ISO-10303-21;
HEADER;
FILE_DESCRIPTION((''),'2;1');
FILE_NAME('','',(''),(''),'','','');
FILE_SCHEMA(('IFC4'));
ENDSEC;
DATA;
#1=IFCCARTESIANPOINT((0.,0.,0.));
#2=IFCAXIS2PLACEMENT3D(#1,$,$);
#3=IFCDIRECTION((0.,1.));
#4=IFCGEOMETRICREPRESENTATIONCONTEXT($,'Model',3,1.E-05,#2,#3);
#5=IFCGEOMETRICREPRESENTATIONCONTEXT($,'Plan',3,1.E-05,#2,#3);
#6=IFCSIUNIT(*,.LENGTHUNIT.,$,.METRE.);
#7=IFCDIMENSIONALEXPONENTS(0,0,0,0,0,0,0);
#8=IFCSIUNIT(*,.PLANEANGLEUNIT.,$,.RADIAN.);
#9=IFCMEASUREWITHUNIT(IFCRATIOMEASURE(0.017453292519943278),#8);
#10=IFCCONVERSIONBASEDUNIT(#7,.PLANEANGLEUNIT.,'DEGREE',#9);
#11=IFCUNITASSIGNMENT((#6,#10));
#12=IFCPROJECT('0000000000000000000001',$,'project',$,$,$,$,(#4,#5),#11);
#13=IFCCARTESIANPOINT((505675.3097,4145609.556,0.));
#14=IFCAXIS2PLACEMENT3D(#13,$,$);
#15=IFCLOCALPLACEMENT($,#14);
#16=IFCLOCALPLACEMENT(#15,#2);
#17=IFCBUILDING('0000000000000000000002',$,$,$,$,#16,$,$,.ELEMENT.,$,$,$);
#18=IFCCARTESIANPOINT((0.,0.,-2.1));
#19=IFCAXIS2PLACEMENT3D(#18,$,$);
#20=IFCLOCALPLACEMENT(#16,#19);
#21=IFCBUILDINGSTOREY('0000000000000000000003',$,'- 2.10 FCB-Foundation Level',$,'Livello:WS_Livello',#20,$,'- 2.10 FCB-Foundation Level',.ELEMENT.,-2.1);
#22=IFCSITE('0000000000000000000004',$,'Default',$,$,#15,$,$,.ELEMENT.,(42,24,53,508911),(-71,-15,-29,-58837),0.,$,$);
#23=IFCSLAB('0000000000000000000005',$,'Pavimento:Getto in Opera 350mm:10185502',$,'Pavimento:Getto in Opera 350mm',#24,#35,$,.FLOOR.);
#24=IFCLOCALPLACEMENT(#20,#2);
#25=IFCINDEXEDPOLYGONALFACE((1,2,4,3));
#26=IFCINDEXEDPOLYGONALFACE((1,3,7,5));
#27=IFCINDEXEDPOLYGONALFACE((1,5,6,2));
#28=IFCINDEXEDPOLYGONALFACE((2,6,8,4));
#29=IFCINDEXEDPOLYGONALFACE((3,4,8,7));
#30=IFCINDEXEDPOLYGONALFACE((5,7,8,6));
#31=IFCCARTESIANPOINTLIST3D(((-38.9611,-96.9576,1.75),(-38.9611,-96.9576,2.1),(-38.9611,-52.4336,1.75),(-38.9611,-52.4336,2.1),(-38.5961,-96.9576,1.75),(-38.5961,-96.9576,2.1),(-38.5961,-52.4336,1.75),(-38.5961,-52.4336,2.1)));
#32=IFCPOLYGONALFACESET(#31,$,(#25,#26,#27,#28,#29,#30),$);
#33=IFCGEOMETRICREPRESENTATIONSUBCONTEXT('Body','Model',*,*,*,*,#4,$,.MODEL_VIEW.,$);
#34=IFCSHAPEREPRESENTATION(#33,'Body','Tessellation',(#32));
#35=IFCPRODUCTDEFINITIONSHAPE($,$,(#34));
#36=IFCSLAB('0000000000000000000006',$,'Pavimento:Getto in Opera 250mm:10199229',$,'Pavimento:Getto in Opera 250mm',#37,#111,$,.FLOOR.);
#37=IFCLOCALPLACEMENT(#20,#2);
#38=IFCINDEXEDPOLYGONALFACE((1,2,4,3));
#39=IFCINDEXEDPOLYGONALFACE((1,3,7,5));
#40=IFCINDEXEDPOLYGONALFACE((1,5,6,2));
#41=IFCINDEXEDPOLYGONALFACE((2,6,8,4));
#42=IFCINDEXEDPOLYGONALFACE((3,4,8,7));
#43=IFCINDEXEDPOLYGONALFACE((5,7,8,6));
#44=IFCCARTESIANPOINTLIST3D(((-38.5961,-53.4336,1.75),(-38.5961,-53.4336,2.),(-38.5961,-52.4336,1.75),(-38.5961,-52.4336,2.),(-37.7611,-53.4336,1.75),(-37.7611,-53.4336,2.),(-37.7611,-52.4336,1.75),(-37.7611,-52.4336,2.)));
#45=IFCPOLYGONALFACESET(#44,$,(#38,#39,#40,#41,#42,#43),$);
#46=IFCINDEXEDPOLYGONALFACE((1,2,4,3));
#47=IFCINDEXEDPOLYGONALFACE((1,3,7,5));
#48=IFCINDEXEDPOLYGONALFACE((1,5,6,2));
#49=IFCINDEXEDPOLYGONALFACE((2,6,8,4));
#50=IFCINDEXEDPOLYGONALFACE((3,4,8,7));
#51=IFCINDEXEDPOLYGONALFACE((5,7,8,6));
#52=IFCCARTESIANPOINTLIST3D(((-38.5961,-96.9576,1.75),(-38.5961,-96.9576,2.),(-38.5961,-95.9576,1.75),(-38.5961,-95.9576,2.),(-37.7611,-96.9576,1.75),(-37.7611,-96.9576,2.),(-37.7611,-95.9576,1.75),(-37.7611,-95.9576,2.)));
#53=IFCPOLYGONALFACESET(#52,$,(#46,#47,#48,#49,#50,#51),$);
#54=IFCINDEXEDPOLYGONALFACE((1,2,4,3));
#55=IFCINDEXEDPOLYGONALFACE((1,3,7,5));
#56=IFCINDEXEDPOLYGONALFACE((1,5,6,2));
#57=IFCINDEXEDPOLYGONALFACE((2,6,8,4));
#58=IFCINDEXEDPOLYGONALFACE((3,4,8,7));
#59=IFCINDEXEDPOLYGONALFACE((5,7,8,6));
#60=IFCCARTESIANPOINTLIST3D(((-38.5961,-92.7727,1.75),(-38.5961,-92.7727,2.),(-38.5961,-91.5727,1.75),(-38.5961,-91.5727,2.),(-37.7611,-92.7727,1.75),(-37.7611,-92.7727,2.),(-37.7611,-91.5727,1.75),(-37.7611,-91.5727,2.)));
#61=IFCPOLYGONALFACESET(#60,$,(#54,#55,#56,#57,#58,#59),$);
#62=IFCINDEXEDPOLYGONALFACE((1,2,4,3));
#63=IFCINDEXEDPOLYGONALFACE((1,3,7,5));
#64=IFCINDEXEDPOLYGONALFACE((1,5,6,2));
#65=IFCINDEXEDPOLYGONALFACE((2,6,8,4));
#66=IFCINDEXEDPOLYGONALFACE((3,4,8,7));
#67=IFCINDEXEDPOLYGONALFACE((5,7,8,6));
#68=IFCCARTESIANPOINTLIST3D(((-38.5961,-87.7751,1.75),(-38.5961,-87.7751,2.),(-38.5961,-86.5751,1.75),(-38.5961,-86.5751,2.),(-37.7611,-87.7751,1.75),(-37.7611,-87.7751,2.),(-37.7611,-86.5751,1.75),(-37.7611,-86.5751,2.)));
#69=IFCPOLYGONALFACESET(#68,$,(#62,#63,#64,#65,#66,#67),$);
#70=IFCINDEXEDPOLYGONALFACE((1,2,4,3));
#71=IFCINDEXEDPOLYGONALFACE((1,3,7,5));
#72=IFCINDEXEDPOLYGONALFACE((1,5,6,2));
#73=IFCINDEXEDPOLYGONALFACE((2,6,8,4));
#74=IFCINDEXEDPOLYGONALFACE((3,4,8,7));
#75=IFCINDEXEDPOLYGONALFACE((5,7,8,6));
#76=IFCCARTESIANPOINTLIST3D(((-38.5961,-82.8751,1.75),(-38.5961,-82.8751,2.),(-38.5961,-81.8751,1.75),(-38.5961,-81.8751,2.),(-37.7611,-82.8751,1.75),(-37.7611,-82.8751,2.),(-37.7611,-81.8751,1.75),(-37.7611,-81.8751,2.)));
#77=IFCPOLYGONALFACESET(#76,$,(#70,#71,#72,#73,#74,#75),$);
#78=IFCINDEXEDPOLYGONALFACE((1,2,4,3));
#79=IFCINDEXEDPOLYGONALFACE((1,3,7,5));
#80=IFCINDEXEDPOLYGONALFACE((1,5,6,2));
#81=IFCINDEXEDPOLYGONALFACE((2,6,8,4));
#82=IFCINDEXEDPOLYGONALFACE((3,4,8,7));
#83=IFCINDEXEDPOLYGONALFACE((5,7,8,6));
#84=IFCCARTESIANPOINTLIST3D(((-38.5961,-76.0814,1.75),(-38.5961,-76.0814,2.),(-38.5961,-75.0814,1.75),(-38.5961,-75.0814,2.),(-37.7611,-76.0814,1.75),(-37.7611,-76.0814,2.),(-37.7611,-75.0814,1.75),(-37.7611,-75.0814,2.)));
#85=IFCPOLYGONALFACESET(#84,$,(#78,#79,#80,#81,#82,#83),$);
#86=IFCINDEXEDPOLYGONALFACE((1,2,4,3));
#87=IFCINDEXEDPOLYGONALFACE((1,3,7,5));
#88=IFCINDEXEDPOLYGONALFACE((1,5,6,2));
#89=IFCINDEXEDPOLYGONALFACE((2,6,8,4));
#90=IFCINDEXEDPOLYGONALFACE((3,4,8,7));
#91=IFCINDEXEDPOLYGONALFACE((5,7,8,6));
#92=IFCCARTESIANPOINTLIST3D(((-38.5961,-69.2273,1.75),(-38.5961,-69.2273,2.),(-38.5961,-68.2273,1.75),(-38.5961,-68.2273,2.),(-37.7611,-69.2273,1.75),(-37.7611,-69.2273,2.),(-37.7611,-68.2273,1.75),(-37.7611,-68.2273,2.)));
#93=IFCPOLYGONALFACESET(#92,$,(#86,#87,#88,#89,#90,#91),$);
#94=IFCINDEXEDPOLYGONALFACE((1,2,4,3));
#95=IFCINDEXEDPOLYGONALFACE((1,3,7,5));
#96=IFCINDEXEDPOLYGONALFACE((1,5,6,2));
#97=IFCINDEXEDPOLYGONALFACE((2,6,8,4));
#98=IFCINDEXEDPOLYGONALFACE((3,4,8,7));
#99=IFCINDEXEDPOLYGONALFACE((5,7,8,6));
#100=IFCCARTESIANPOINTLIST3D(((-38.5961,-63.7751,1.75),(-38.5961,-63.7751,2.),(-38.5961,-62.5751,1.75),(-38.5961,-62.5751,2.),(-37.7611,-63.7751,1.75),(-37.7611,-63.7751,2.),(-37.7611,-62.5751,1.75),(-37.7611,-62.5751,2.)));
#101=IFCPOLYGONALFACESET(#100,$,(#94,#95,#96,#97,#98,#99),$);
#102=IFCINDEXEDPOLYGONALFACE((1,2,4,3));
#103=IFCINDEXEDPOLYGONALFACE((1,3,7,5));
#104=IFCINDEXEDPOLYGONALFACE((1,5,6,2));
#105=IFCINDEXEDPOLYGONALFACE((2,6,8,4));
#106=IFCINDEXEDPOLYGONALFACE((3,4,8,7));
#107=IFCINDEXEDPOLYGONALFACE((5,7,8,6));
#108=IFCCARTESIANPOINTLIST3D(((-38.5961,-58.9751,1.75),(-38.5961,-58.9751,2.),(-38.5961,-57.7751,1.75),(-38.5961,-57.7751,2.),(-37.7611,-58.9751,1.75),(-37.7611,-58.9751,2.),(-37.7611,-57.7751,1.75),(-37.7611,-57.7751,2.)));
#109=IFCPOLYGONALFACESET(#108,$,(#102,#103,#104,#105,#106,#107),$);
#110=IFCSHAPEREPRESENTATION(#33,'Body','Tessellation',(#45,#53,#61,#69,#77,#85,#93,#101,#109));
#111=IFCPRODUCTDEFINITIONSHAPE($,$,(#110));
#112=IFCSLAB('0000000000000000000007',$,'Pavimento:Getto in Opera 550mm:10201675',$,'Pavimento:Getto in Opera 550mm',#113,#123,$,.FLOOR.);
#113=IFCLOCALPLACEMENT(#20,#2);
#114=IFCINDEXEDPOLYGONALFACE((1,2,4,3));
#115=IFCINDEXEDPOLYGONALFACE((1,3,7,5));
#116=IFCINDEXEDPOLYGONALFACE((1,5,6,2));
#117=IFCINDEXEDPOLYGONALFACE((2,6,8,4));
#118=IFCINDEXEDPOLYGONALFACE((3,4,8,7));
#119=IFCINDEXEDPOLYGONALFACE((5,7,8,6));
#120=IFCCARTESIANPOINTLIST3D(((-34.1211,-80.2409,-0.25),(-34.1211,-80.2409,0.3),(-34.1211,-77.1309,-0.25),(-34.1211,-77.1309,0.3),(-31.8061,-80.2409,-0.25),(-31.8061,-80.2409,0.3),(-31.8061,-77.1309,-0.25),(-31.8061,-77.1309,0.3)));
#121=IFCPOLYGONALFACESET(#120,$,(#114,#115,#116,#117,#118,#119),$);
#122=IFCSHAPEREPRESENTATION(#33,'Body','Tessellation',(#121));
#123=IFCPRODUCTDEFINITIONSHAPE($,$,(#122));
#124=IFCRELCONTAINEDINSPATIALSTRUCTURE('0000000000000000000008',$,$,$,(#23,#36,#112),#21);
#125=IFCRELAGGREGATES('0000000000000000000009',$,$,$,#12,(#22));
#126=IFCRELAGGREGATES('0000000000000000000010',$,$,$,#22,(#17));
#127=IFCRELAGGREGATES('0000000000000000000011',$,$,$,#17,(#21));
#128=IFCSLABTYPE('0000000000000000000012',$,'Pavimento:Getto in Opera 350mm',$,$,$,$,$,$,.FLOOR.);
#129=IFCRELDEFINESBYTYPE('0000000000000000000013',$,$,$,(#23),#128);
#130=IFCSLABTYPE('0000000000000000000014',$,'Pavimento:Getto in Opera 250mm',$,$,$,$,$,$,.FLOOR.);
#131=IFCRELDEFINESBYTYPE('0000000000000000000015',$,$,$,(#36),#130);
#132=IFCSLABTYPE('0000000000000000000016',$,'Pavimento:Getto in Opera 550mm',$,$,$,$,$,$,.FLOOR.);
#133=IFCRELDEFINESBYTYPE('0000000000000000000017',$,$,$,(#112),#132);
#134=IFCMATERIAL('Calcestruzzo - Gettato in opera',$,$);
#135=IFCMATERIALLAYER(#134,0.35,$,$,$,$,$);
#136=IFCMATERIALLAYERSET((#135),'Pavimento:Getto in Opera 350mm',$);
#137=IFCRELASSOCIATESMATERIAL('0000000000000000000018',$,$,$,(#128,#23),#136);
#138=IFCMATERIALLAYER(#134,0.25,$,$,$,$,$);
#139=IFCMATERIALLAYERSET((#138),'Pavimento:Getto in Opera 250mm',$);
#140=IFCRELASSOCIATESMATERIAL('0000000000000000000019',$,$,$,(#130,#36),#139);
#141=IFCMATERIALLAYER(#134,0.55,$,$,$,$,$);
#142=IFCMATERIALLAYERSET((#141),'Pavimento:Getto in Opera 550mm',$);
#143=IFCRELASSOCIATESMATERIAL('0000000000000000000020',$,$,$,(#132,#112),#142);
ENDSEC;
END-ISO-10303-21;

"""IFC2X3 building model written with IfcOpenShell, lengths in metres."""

from ifc_helpers import new_model, entity, si_unit, converted_unit, direction, frame, frame_2d, origin, place, context, subcontext, project, spatial, rectangle, extrude, material, layer, layer_set, layer_usage, type_object, element, save


model = new_model("IFC2X3")

# Units and contexts
model_context = context("Model", 3, precision=1e-05, world=origin(), true_north=direction((0.0, 1.0)))
plan_context = context("Plan", 3, precision=1e-05, world=origin(), true_north=direction((0.0, 1.0)))
body_context = subcontext(model_context, "Body", "Model", "MODEL_VIEW")
ifc_project = project(units=[si_unit("LENGTHUNIT", "METRE"), converted_unit("PLANEANGLEUNIT", "DEGREE", entity("IfcRatioMeasure", 0.017453292519943278), si_unit("PLANEANGLEUNIT", "RADIAN"), dimensions=[0, 0, 0, 0, 0, 0, 0])], contexts=[model_context, plan_context])

# Site, building, storey
site_placement = place(None, frame((505675.3097, 4145609.556, 0.0)))
site = spatial("IfcSite", under=ifc_project, at=site_placement, Name="Default", CompositionType="ELEMENT", RefLatitude=(42, 24, 53, 508911), RefLongitude=(-71, -15, -29, -58837), RefElevation=0.0)
building_placement = place(site_placement, origin())
building = spatial("IfcBuilding", under=site, at=building_placement, CompositionType="ELEMENT")
storey_placement = place(building_placement, frame((0.0, 0.0, -2.1)))
storey = spatial("IfcBuildingStorey", under=building, at=storey_placement, Name="- 2.10 FCB-Foundation Level", ObjectType="Livello:WS_Livello", LongName="- 2.10 FCB-Foundation Level", CompositionType="ELEMENT", Elevation=-2.1)

# Slab
ifc_material_1 = material(Name="Calcestruzzo - Gettato in opera")
ifc_layer_1 = layer(ifc_material_1, 0.35)
ifc_layer_set_1 = layer_set([ifc_layer_1], Name="Pavimento:Getto in Opera 350mm")
ifc_layer_usage_1 = layer_usage(ifc_layer_set_1, "AXIS3", "POSITIVE", 0.0)
slab_type_1 = type_object("IfcSlabType", Name="Pavimento:Getto in Opera 350mm", PredefinedType="FLOOR", material=ifc_layer_set_1)
slab_1_placement = place(storey_placement, origin())
element("IfcSlab", 1, at=slab_1_placement, inside=storey, type_object=slab_type_1, material=ifc_layer_usage_1, Name="Pavimento:Getto in Opera 350mm:10185502", ObjectType="Pavimento:Getto in Opera 350mm", PredefinedType="FLOOR", context=body_context, shape_type="SweptSolid", body=[
    extrude(rectangle(XDim=44.524, YDim=0.365, at=frame_2d((0.0, 0.0), x_axis=(1.0, 0.0))), frame((-38.7786, -74.6956, 2.1), z_axis=(0.0, 0.0, -1.0), x_axis=(0.0, 1.0, 0.0)), (0.0, 0.0, 1.0), 0.35),
])

# Slabs
ifc_layer_2 = layer(ifc_material_1, 0.25)
ifc_layer_set_2 = layer_set([ifc_layer_2], Name="Pavimento:Getto in Opera 250mm")
ifc_layer_usage_2 = layer_usage(ifc_layer_set_2, "AXIS3", "POSITIVE", 0.0)
slab_type_2 = type_object("IfcSlabType", Name="Pavimento:Getto in Opera 250mm", PredefinedType="FLOOR", material=ifc_layer_set_2)
slab_2_placement = place(storey_placement, origin())
element("IfcSlab", 2, at=slab_2_placement, inside=storey, type_object=slab_type_2, material=ifc_layer_usage_2, Name="Pavimento:Getto in Opera 250mm:10199229", ObjectType="Pavimento:Getto in Opera 250mm", PredefinedType="FLOOR", context=body_context, shape_type="SweptSolid", body=[
    extrude(rectangle(XDim=0.835, YDim=1.0, at=frame_2d((0.0, 0.0), x_axis=(1.0, 0.0))), frame((-38.1786, -52.9336, 1.75), z_axis=(0.0, 0.0, 1.0), x_axis=(-1.0, 0.0, 0.0)), (0.0, 0.0, 1.0), 0.25),
    extrude(rectangle(XDim=0.8349, YDim=1.0, at=frame_2d((0.0, 0.0), x_axis=(1.0, 0.0))), frame((-38.1786, -96.4576, 1.75), z_axis=(0.0, 0.0, 1.0), x_axis=(-1.0, 0.0, 0.0)), (0.0, 0.0, 1.0), 0.25),
    extrude(rectangle(XDim=0.835, YDim=1.2, at=frame_2d((0.0, 0.0), x_axis=(1.0, 0.0))), frame((-38.1786, -92.1727, 1.75), z_axis=(0.0, 0.0, 1.0), x_axis=(-1.0, 0.0, 0.0)), (0.0, 0.0, 1.0), 0.25),
    extrude(rectangle(XDim=0.835, YDim=1.2, at=frame_2d((0.0, 0.0), x_axis=(1.0, 0.0))), frame((-38.1786, -87.1751, 1.75), z_axis=(0.0, 0.0, 1.0), x_axis=(-1.0, 0.0, 0.0)), (0.0, 0.0, 1.0), 0.25),
    extrude(rectangle(XDim=0.835, YDim=1.0, at=frame_2d((0.0, 0.0), x_axis=(1.0, 0.0))), frame((-38.1786, -82.3751, 1.75), z_axis=(0.0, 0.0, 1.0), x_axis=(-1.0, 0.0, 0.0)), (0.0, 0.0, 1.0), 0.25),
    extrude(rectangle(XDim=0.835, YDim=1.0, at=frame_2d((0.0, 0.0), x_axis=(1.0, 0.0))), frame((-38.1786, -75.5814, 1.75), z_axis=(0.0, 0.0, 1.0), x_axis=(-1.0, 0.0, 0.0)), (0.0, 0.0, 1.0), 0.25),
    extrude(rectangle(XDim=0.835, YDim=1.0, at=frame_2d((0.0, 0.0), x_axis=(1.0, 0.0))), frame((-38.1786, -68.7273, 1.75), z_axis=(0.0, 0.0, 1.0), x_axis=(-1.0, 0.0, 0.0)), (0.0, 0.0, 1.0), 0.25),
    extrude(rectangle(XDim=0.835, YDim=1.2, at=frame_2d((0.0, 0.0), x_axis=(1.0, 0.0))), frame((-38.1786, -63.1751, 1.75), z_axis=(0.0, 0.0, 1.0), x_axis=(-1.0, 0.0, 0.0)), (0.0, 0.0, 1.0), 0.25),
    extrude(rectangle(XDim=0.835, YDim=1.2, at=frame_2d((0.0, 0.0), x_axis=(1.0, 0.0))), frame((-38.1786, -58.3751, 1.75), z_axis=(0.0, 0.0, 1.0), x_axis=(-1.0, 0.0, 0.0)), (0.0, 0.0, 1.0), 0.25),
])
ifc_layer_3 = layer(ifc_material_1, 0.55)
ifc_layer_set_3 = layer_set([ifc_layer_3], Name="Pavimento:Getto in Opera 550mm")
ifc_layer_usage_3 = layer_usage(ifc_layer_set_3, "AXIS3", "POSITIVE", 0.0)
slab_type_3 = type_object("IfcSlabType", Name="Pavimento:Getto in Opera 550mm", PredefinedType="FLOOR", material=ifc_layer_set_3)
slab_3_placement = place(storey_placement, origin())
element("IfcSlab", 3, at=slab_3_placement, inside=storey, type_object=slab_type_3, material=ifc_layer_usage_3, Name="Pavimento:Getto in Opera 550mm:10201675", ObjectType="Pavimento:Getto in Opera 550mm", PredefinedType="FLOOR", context=body_context, shape_type="SweptSolid", body=[
    extrude(rectangle(XDim=3.11, YDim=2.315, at=frame_2d((0.0, 0.0), x_axis=(1.0, 0.0))), frame((-32.9636, -78.6859, 0.3), z_axis=(0.0, 0.0, -1.0), x_axis=(0.0, 1.0, 0.0)), (0.0, 0.0, 1.0), 0.55),
])

save(model, "model.ifc")
